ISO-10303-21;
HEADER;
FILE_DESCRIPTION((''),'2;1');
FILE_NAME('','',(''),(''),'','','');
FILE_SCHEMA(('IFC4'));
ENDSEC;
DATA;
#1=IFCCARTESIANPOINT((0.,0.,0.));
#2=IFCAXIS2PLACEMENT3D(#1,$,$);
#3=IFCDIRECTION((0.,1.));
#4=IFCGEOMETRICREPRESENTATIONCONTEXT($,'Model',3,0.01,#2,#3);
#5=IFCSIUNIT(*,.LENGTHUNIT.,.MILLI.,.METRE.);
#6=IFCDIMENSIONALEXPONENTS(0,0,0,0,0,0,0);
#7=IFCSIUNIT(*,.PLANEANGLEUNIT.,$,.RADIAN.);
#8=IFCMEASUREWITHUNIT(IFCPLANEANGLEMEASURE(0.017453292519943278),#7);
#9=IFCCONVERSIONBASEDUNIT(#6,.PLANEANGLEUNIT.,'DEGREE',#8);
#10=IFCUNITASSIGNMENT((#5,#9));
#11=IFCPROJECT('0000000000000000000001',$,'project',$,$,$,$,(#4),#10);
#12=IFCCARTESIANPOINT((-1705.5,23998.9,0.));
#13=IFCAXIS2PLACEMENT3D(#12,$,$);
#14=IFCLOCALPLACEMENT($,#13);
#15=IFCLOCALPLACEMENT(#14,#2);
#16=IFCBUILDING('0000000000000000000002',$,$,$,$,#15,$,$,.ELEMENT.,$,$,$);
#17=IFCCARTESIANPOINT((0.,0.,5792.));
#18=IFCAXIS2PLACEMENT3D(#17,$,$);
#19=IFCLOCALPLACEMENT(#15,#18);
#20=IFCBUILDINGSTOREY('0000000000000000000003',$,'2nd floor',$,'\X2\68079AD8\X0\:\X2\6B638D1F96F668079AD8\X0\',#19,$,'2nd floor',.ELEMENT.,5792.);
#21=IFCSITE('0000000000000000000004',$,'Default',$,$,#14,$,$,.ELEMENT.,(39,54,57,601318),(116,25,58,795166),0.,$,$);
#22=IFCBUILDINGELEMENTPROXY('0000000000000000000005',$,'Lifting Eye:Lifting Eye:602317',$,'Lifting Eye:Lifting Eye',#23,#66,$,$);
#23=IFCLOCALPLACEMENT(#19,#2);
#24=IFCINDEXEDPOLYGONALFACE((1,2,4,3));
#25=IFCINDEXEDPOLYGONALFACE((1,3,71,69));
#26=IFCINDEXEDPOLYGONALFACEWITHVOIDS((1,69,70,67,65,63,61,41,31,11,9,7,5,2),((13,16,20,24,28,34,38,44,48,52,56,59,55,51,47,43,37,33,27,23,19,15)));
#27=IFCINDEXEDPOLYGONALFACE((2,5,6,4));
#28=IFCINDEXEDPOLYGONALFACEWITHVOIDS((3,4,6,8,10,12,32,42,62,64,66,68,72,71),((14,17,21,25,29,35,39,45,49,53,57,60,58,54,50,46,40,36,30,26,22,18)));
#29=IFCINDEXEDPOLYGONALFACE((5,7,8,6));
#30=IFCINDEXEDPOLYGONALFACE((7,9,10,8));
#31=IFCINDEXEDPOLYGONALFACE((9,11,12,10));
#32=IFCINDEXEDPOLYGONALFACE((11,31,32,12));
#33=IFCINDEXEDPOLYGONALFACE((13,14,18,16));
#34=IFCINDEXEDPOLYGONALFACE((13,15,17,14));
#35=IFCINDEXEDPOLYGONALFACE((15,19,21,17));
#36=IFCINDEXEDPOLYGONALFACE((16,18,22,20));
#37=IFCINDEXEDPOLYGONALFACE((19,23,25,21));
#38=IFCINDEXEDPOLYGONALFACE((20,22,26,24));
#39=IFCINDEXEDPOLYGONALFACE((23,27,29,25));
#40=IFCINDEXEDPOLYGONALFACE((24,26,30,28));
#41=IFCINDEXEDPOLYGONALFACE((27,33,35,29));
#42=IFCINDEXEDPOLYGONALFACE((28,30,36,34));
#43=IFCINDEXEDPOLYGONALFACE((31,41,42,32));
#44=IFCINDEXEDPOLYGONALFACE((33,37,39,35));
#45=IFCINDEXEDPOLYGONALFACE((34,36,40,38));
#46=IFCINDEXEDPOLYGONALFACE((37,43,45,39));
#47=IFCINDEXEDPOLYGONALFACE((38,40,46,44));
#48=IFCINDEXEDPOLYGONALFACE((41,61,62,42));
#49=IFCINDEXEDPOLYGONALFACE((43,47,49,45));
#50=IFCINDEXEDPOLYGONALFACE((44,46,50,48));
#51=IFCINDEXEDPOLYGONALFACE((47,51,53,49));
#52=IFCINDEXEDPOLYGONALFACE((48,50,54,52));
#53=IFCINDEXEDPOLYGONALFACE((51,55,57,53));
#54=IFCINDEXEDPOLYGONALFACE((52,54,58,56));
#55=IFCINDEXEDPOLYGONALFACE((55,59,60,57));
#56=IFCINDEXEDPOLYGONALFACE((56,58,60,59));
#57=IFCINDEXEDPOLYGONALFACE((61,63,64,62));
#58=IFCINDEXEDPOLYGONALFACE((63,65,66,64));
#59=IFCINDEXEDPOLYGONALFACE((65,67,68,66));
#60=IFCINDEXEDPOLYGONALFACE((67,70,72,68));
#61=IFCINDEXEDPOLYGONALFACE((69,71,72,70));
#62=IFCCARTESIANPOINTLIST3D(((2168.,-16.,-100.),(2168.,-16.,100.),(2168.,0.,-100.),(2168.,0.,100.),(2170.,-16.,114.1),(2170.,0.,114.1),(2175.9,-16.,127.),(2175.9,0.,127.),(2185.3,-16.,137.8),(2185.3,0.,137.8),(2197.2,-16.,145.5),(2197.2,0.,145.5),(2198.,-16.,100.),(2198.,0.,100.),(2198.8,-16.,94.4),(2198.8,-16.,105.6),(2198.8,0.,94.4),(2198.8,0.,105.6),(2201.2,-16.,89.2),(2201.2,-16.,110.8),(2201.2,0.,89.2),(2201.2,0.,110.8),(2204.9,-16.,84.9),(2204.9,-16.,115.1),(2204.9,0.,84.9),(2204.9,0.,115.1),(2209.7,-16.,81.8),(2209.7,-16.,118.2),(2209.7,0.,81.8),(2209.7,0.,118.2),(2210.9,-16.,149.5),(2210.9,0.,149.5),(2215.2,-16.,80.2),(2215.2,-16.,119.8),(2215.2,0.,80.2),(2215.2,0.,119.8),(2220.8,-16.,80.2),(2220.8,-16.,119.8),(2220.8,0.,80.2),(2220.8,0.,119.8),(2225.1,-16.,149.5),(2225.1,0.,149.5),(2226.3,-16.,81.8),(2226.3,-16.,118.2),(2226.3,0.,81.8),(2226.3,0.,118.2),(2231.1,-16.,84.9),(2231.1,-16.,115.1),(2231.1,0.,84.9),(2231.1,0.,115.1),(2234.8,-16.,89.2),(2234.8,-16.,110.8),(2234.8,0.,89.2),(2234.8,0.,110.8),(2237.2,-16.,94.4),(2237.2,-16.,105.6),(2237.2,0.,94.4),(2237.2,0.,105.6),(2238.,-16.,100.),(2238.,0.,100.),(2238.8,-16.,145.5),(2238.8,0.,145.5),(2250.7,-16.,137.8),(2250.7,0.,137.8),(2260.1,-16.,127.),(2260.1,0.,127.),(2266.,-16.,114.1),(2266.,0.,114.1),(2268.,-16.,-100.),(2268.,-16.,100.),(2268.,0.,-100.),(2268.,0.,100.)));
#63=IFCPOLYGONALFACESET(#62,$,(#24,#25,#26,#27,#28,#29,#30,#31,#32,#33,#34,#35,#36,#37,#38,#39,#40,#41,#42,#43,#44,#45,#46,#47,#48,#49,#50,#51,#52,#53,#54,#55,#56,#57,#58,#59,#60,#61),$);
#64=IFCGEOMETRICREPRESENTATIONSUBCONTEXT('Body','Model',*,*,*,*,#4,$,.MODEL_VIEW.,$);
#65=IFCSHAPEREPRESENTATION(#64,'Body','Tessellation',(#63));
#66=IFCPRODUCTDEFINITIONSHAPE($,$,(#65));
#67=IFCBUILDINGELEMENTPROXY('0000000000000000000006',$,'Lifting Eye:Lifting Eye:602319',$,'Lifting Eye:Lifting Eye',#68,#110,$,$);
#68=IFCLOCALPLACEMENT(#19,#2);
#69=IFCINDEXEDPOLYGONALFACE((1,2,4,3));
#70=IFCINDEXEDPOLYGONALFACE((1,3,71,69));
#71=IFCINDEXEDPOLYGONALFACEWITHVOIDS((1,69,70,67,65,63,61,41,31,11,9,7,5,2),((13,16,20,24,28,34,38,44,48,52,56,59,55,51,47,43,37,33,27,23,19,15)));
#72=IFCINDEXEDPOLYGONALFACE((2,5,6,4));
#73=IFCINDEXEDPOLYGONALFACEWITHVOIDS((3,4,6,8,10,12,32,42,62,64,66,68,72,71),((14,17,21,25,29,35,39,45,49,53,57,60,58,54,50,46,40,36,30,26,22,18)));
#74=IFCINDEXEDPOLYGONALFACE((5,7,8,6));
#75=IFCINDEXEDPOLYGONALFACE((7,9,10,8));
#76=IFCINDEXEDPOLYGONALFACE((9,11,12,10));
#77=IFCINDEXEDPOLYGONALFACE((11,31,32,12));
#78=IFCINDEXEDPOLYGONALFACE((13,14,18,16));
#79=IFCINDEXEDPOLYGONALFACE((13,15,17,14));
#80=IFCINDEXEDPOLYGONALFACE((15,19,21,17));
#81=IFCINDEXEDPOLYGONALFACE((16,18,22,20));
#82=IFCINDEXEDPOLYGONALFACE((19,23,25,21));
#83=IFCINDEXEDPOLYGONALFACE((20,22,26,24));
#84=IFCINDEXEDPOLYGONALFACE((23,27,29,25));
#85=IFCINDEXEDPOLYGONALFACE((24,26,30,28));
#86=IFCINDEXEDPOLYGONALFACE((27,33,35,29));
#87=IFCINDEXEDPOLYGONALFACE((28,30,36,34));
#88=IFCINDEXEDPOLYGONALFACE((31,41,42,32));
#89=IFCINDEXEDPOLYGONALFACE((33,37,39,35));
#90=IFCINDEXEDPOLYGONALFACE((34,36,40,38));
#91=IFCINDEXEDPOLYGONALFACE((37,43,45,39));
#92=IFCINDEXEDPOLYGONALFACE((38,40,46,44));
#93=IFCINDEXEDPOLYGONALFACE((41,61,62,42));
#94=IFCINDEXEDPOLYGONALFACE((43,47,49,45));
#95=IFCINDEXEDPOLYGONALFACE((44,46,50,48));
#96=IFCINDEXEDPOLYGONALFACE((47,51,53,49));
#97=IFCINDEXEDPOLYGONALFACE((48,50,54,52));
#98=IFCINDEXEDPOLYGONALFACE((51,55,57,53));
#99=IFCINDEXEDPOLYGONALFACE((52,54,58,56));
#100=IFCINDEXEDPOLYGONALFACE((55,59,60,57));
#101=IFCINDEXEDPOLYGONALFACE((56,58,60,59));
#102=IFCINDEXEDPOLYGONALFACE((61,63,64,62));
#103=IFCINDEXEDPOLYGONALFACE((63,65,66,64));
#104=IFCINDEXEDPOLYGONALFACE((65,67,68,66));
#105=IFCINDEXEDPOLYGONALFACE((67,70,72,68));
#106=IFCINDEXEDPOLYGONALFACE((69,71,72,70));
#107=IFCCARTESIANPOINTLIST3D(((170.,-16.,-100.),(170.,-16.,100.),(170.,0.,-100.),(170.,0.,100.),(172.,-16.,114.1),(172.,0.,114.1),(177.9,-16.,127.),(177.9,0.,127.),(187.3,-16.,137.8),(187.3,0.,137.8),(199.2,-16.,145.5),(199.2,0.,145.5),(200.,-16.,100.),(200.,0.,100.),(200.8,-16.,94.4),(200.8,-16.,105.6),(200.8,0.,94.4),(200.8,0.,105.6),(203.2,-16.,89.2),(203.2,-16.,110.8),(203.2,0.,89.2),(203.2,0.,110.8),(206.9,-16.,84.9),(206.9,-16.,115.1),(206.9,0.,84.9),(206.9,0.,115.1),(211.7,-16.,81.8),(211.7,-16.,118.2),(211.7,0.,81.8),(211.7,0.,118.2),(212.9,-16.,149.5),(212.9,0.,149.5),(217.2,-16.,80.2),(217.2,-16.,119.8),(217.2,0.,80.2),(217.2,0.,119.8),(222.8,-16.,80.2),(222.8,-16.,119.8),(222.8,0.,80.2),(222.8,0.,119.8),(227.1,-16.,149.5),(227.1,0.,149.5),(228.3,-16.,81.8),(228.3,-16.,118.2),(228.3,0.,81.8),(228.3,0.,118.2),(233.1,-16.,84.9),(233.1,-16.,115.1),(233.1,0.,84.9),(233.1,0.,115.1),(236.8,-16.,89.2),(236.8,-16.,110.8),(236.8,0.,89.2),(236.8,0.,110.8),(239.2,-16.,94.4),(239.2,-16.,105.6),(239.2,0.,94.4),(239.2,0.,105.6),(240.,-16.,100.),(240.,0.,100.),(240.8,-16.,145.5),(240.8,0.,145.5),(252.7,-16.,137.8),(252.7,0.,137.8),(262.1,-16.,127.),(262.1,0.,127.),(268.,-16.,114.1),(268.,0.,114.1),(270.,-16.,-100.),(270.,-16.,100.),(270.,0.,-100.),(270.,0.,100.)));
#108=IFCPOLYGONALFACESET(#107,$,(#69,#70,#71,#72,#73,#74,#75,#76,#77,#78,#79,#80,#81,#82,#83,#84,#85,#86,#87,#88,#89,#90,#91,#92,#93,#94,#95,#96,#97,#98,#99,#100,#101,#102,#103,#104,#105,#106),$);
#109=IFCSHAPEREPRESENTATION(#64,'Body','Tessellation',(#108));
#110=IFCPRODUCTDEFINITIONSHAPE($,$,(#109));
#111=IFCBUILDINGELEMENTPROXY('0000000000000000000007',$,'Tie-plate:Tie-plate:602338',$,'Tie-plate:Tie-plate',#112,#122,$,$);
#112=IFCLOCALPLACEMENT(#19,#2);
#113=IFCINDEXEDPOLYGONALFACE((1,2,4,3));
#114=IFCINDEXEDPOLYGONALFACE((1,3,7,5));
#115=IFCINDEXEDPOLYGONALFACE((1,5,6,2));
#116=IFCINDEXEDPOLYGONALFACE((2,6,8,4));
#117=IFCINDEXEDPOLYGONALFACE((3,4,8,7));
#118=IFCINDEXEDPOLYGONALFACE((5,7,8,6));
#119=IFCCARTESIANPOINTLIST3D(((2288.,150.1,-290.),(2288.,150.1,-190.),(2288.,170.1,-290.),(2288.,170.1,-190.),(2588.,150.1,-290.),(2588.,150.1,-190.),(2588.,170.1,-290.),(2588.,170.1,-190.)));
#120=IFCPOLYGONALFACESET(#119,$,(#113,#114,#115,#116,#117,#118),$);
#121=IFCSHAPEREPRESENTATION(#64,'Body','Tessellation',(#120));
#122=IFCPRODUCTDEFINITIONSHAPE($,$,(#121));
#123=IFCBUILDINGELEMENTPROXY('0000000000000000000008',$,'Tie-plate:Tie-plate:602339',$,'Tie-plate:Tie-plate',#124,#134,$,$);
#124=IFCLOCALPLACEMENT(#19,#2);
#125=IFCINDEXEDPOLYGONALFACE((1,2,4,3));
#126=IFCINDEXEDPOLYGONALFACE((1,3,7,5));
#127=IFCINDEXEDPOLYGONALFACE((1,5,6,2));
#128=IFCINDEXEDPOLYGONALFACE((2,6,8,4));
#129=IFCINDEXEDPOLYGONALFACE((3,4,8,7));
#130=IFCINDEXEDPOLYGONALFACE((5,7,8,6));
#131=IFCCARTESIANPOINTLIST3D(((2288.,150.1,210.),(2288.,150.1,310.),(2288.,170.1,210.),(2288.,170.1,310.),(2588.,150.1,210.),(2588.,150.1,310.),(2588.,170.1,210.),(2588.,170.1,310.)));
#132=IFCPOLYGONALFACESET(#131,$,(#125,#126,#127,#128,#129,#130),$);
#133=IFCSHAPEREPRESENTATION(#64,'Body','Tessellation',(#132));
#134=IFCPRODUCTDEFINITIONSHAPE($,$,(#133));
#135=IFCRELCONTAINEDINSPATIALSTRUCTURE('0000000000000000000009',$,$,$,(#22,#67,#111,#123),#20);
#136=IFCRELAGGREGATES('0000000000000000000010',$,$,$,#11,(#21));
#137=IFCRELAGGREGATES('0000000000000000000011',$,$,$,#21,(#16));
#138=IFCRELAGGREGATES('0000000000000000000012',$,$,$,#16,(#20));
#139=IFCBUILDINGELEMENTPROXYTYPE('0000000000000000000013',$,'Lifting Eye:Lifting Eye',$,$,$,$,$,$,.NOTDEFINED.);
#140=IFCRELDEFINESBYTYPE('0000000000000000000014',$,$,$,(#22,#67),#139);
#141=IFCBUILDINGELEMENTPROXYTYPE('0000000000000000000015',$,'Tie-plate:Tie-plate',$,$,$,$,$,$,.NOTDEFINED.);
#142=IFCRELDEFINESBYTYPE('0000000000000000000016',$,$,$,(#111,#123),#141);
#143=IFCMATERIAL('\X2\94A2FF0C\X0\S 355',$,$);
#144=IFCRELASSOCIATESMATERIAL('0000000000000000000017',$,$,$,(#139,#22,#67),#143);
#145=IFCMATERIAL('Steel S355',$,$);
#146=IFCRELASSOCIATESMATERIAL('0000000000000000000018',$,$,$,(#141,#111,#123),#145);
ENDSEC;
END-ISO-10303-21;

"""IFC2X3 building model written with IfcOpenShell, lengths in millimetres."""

from ifc_helpers import new_model, entity, si_unit, converted_unit, direction, frame, frame_2d, origin, place, context, subcontext, project, spatial, polyline, circle_curve, parameter, trimmed, segment, composite_curve, rectangle, outline, extrude, source, transform, mapped, material, type_object, type_shapes, element, save


model = new_model("IFC2X3")

# Units and contexts
model_context = context("Model", 3, precision=0.01, world=origin(), true_north=direction((0.0, 1.0)))
body_context = subcontext(model_context, "Body", "Model", "MODEL_VIEW")
ifc_project = project(units=[si_unit("LENGTHUNIT", "METRE", prefix="MILLI"), converted_unit("PLANEANGLEUNIT", "DEGREE", entity("IfcPlaneAngleMeasure", 0.017453292519943278), si_unit("PLANEANGLEUNIT", "RADIAN"), dimensions=[0, 0, 0, 0, 0, 0, 0])], contexts=[model_context])

# Site, building, storey
site_placement = place(None, frame((-1705.5, 23998.9, 0.0)))
site = spatial("IfcSite", under=ifc_project, at=site_placement, Name="Default", CompositionType="ELEMENT", RefLatitude=(39, 54, 57, 601318), RefLongitude=(116, 25, 58, 795166), RefElevation=0.0)
building_placement = place(site_placement, origin())
building = spatial("IfcBuilding", under=site, at=building_placement, CompositionType="ELEMENT")
storey_placement = place(building_placement, frame((0.0, 0.0, 5792.0)))
storey = spatial("IfcBuildingStorey", under=building, at=storey_placement, Name="2nd floor", ObjectType="标高:正负零标高", LongName="2nd floor", CompositionType="ELEMENT", Elevation=5792.0)

# Shared definitions
ifc_material_1 = material(Name="Steel S355")

# Building element proxies
ifc_material_2 = material(Name="钢，S 355")
building_element_proxy_type_1 = type_object("IfcBuildingElementProxyType", Name="Lifting Eye:Lifting Eye", PredefinedType="NOTDEFINED", material=ifc_material_2)
shared_shape_1 = source(origin(), body_context, "Body", "SweptSolid", [
    extrude(outline(composite_curve([segment(polyline([(-100.0, -50.0), (100.0, -50.0)]), True, "CONTINUOUS"), segment(polyline([(100.0, -50.0), (100.0, 50.0)]), True, "CONTINUOUS"), segment(polyline([(100.0, 50.0), (-100.0, 50.0)]), True, "CONTINUOUS"), segment(trimmed(circle_curve(frame_2d((-100.0, 0.0), x_axis=(0.0, -1.0)), 50.0), [parameter(180.0)], [parameter(0.0)], True, "PARAMETER"), True, "CONTINUOUS")], self_intersect=False), holes=[composite_curve([segment(trimmed(circle_curve(frame_2d((-100.0, 0.0), x_axis=(0.0, -1.0)), 20.0), [parameter(180.0)], [parameter(360.0)], True, "PARAMETER"), False, "CONTINUOUS"), segment(trimmed(circle_curve(frame_2d((-100.0, 0.0), x_axis=(0.0, -1.0)), 20.0), [parameter(0.0)], [parameter(180.0)], True, "PARAMETER"), False, "CONTINUOUS")], self_intersect=False)]), frame((0.0, 17.0, -17.0), z_axis=(0.0, 1.0, 0.0), x_axis=(0.0, 0.0, -1.0)), (0.0, 0.0, 1.0), 16.0),
])
type_shapes(building_element_proxy_type_1, [shared_shape_1])
for number, where, name in (
    (1, (2218.0, -33.0, 17.0), "Lifting Eye:Lifting Eye:602317"),
    (2, (220.0, -33.0, 17.0), "Lifting Eye:Lifting Eye:602319"),
):
    element("IfcBuildingElementProxy", number, at=place(storey_placement, frame(where)), inside=storey, type_object=building_element_proxy_type_1, material=ifc_material_2, Name=name, ObjectType="Lifting Eye:Lifting Eye", context=body_context, shape_type="MappedRepresentation", body=[
        mapped(shared_shape_1, transform((0.0, 0.0, 0.0), scale=1.0)),
    ])
building_element_proxy_type_2 = type_object("IfcBuildingElementProxyType", Name="Tie-plate:Tie-plate", PredefinedType="NOTDEFINED", material=ifc_material_1)
shared_shape_2 = source(origin(), body_context, "Body", "SweptSolid", [
    extrude(rectangle(XDim=20.0, YDim=300.0, at=frame_2d((0.0, 0.0), x_axis=(1.0, 0.0))), frame((150.0, 10.0, 0.0), z_axis=(0.0, 0.0, 1.0), x_axis=(0.0, 1.0, 0.0)), (0.0, 0.0, 1.0), 100.0),
])
type_shapes(building_element_proxy_type_2, [shared_shape_2])
for number, where, name in (
    (3, (2288.0, 150.1, -290.0), "Tie-plate:Tie-plate:602338"),
    (4, (2288.0, 150.1, 210.0), "Tie-plate:Tie-plate:602339"),
):
    element("IfcBuildingElementProxy", number, at=place(storey_placement, frame(where)), inside=storey, type_object=building_element_proxy_type_2, material=ifc_material_1, Name=name, ObjectType="Tie-plate:Tie-plate", context=body_context, shape_type="MappedRepresentation", body=[
        mapped(shared_shape_2, transform((0.0, 0.0, 0.0), scale=1.0)),
    ])

save(model, "model.ifc")
